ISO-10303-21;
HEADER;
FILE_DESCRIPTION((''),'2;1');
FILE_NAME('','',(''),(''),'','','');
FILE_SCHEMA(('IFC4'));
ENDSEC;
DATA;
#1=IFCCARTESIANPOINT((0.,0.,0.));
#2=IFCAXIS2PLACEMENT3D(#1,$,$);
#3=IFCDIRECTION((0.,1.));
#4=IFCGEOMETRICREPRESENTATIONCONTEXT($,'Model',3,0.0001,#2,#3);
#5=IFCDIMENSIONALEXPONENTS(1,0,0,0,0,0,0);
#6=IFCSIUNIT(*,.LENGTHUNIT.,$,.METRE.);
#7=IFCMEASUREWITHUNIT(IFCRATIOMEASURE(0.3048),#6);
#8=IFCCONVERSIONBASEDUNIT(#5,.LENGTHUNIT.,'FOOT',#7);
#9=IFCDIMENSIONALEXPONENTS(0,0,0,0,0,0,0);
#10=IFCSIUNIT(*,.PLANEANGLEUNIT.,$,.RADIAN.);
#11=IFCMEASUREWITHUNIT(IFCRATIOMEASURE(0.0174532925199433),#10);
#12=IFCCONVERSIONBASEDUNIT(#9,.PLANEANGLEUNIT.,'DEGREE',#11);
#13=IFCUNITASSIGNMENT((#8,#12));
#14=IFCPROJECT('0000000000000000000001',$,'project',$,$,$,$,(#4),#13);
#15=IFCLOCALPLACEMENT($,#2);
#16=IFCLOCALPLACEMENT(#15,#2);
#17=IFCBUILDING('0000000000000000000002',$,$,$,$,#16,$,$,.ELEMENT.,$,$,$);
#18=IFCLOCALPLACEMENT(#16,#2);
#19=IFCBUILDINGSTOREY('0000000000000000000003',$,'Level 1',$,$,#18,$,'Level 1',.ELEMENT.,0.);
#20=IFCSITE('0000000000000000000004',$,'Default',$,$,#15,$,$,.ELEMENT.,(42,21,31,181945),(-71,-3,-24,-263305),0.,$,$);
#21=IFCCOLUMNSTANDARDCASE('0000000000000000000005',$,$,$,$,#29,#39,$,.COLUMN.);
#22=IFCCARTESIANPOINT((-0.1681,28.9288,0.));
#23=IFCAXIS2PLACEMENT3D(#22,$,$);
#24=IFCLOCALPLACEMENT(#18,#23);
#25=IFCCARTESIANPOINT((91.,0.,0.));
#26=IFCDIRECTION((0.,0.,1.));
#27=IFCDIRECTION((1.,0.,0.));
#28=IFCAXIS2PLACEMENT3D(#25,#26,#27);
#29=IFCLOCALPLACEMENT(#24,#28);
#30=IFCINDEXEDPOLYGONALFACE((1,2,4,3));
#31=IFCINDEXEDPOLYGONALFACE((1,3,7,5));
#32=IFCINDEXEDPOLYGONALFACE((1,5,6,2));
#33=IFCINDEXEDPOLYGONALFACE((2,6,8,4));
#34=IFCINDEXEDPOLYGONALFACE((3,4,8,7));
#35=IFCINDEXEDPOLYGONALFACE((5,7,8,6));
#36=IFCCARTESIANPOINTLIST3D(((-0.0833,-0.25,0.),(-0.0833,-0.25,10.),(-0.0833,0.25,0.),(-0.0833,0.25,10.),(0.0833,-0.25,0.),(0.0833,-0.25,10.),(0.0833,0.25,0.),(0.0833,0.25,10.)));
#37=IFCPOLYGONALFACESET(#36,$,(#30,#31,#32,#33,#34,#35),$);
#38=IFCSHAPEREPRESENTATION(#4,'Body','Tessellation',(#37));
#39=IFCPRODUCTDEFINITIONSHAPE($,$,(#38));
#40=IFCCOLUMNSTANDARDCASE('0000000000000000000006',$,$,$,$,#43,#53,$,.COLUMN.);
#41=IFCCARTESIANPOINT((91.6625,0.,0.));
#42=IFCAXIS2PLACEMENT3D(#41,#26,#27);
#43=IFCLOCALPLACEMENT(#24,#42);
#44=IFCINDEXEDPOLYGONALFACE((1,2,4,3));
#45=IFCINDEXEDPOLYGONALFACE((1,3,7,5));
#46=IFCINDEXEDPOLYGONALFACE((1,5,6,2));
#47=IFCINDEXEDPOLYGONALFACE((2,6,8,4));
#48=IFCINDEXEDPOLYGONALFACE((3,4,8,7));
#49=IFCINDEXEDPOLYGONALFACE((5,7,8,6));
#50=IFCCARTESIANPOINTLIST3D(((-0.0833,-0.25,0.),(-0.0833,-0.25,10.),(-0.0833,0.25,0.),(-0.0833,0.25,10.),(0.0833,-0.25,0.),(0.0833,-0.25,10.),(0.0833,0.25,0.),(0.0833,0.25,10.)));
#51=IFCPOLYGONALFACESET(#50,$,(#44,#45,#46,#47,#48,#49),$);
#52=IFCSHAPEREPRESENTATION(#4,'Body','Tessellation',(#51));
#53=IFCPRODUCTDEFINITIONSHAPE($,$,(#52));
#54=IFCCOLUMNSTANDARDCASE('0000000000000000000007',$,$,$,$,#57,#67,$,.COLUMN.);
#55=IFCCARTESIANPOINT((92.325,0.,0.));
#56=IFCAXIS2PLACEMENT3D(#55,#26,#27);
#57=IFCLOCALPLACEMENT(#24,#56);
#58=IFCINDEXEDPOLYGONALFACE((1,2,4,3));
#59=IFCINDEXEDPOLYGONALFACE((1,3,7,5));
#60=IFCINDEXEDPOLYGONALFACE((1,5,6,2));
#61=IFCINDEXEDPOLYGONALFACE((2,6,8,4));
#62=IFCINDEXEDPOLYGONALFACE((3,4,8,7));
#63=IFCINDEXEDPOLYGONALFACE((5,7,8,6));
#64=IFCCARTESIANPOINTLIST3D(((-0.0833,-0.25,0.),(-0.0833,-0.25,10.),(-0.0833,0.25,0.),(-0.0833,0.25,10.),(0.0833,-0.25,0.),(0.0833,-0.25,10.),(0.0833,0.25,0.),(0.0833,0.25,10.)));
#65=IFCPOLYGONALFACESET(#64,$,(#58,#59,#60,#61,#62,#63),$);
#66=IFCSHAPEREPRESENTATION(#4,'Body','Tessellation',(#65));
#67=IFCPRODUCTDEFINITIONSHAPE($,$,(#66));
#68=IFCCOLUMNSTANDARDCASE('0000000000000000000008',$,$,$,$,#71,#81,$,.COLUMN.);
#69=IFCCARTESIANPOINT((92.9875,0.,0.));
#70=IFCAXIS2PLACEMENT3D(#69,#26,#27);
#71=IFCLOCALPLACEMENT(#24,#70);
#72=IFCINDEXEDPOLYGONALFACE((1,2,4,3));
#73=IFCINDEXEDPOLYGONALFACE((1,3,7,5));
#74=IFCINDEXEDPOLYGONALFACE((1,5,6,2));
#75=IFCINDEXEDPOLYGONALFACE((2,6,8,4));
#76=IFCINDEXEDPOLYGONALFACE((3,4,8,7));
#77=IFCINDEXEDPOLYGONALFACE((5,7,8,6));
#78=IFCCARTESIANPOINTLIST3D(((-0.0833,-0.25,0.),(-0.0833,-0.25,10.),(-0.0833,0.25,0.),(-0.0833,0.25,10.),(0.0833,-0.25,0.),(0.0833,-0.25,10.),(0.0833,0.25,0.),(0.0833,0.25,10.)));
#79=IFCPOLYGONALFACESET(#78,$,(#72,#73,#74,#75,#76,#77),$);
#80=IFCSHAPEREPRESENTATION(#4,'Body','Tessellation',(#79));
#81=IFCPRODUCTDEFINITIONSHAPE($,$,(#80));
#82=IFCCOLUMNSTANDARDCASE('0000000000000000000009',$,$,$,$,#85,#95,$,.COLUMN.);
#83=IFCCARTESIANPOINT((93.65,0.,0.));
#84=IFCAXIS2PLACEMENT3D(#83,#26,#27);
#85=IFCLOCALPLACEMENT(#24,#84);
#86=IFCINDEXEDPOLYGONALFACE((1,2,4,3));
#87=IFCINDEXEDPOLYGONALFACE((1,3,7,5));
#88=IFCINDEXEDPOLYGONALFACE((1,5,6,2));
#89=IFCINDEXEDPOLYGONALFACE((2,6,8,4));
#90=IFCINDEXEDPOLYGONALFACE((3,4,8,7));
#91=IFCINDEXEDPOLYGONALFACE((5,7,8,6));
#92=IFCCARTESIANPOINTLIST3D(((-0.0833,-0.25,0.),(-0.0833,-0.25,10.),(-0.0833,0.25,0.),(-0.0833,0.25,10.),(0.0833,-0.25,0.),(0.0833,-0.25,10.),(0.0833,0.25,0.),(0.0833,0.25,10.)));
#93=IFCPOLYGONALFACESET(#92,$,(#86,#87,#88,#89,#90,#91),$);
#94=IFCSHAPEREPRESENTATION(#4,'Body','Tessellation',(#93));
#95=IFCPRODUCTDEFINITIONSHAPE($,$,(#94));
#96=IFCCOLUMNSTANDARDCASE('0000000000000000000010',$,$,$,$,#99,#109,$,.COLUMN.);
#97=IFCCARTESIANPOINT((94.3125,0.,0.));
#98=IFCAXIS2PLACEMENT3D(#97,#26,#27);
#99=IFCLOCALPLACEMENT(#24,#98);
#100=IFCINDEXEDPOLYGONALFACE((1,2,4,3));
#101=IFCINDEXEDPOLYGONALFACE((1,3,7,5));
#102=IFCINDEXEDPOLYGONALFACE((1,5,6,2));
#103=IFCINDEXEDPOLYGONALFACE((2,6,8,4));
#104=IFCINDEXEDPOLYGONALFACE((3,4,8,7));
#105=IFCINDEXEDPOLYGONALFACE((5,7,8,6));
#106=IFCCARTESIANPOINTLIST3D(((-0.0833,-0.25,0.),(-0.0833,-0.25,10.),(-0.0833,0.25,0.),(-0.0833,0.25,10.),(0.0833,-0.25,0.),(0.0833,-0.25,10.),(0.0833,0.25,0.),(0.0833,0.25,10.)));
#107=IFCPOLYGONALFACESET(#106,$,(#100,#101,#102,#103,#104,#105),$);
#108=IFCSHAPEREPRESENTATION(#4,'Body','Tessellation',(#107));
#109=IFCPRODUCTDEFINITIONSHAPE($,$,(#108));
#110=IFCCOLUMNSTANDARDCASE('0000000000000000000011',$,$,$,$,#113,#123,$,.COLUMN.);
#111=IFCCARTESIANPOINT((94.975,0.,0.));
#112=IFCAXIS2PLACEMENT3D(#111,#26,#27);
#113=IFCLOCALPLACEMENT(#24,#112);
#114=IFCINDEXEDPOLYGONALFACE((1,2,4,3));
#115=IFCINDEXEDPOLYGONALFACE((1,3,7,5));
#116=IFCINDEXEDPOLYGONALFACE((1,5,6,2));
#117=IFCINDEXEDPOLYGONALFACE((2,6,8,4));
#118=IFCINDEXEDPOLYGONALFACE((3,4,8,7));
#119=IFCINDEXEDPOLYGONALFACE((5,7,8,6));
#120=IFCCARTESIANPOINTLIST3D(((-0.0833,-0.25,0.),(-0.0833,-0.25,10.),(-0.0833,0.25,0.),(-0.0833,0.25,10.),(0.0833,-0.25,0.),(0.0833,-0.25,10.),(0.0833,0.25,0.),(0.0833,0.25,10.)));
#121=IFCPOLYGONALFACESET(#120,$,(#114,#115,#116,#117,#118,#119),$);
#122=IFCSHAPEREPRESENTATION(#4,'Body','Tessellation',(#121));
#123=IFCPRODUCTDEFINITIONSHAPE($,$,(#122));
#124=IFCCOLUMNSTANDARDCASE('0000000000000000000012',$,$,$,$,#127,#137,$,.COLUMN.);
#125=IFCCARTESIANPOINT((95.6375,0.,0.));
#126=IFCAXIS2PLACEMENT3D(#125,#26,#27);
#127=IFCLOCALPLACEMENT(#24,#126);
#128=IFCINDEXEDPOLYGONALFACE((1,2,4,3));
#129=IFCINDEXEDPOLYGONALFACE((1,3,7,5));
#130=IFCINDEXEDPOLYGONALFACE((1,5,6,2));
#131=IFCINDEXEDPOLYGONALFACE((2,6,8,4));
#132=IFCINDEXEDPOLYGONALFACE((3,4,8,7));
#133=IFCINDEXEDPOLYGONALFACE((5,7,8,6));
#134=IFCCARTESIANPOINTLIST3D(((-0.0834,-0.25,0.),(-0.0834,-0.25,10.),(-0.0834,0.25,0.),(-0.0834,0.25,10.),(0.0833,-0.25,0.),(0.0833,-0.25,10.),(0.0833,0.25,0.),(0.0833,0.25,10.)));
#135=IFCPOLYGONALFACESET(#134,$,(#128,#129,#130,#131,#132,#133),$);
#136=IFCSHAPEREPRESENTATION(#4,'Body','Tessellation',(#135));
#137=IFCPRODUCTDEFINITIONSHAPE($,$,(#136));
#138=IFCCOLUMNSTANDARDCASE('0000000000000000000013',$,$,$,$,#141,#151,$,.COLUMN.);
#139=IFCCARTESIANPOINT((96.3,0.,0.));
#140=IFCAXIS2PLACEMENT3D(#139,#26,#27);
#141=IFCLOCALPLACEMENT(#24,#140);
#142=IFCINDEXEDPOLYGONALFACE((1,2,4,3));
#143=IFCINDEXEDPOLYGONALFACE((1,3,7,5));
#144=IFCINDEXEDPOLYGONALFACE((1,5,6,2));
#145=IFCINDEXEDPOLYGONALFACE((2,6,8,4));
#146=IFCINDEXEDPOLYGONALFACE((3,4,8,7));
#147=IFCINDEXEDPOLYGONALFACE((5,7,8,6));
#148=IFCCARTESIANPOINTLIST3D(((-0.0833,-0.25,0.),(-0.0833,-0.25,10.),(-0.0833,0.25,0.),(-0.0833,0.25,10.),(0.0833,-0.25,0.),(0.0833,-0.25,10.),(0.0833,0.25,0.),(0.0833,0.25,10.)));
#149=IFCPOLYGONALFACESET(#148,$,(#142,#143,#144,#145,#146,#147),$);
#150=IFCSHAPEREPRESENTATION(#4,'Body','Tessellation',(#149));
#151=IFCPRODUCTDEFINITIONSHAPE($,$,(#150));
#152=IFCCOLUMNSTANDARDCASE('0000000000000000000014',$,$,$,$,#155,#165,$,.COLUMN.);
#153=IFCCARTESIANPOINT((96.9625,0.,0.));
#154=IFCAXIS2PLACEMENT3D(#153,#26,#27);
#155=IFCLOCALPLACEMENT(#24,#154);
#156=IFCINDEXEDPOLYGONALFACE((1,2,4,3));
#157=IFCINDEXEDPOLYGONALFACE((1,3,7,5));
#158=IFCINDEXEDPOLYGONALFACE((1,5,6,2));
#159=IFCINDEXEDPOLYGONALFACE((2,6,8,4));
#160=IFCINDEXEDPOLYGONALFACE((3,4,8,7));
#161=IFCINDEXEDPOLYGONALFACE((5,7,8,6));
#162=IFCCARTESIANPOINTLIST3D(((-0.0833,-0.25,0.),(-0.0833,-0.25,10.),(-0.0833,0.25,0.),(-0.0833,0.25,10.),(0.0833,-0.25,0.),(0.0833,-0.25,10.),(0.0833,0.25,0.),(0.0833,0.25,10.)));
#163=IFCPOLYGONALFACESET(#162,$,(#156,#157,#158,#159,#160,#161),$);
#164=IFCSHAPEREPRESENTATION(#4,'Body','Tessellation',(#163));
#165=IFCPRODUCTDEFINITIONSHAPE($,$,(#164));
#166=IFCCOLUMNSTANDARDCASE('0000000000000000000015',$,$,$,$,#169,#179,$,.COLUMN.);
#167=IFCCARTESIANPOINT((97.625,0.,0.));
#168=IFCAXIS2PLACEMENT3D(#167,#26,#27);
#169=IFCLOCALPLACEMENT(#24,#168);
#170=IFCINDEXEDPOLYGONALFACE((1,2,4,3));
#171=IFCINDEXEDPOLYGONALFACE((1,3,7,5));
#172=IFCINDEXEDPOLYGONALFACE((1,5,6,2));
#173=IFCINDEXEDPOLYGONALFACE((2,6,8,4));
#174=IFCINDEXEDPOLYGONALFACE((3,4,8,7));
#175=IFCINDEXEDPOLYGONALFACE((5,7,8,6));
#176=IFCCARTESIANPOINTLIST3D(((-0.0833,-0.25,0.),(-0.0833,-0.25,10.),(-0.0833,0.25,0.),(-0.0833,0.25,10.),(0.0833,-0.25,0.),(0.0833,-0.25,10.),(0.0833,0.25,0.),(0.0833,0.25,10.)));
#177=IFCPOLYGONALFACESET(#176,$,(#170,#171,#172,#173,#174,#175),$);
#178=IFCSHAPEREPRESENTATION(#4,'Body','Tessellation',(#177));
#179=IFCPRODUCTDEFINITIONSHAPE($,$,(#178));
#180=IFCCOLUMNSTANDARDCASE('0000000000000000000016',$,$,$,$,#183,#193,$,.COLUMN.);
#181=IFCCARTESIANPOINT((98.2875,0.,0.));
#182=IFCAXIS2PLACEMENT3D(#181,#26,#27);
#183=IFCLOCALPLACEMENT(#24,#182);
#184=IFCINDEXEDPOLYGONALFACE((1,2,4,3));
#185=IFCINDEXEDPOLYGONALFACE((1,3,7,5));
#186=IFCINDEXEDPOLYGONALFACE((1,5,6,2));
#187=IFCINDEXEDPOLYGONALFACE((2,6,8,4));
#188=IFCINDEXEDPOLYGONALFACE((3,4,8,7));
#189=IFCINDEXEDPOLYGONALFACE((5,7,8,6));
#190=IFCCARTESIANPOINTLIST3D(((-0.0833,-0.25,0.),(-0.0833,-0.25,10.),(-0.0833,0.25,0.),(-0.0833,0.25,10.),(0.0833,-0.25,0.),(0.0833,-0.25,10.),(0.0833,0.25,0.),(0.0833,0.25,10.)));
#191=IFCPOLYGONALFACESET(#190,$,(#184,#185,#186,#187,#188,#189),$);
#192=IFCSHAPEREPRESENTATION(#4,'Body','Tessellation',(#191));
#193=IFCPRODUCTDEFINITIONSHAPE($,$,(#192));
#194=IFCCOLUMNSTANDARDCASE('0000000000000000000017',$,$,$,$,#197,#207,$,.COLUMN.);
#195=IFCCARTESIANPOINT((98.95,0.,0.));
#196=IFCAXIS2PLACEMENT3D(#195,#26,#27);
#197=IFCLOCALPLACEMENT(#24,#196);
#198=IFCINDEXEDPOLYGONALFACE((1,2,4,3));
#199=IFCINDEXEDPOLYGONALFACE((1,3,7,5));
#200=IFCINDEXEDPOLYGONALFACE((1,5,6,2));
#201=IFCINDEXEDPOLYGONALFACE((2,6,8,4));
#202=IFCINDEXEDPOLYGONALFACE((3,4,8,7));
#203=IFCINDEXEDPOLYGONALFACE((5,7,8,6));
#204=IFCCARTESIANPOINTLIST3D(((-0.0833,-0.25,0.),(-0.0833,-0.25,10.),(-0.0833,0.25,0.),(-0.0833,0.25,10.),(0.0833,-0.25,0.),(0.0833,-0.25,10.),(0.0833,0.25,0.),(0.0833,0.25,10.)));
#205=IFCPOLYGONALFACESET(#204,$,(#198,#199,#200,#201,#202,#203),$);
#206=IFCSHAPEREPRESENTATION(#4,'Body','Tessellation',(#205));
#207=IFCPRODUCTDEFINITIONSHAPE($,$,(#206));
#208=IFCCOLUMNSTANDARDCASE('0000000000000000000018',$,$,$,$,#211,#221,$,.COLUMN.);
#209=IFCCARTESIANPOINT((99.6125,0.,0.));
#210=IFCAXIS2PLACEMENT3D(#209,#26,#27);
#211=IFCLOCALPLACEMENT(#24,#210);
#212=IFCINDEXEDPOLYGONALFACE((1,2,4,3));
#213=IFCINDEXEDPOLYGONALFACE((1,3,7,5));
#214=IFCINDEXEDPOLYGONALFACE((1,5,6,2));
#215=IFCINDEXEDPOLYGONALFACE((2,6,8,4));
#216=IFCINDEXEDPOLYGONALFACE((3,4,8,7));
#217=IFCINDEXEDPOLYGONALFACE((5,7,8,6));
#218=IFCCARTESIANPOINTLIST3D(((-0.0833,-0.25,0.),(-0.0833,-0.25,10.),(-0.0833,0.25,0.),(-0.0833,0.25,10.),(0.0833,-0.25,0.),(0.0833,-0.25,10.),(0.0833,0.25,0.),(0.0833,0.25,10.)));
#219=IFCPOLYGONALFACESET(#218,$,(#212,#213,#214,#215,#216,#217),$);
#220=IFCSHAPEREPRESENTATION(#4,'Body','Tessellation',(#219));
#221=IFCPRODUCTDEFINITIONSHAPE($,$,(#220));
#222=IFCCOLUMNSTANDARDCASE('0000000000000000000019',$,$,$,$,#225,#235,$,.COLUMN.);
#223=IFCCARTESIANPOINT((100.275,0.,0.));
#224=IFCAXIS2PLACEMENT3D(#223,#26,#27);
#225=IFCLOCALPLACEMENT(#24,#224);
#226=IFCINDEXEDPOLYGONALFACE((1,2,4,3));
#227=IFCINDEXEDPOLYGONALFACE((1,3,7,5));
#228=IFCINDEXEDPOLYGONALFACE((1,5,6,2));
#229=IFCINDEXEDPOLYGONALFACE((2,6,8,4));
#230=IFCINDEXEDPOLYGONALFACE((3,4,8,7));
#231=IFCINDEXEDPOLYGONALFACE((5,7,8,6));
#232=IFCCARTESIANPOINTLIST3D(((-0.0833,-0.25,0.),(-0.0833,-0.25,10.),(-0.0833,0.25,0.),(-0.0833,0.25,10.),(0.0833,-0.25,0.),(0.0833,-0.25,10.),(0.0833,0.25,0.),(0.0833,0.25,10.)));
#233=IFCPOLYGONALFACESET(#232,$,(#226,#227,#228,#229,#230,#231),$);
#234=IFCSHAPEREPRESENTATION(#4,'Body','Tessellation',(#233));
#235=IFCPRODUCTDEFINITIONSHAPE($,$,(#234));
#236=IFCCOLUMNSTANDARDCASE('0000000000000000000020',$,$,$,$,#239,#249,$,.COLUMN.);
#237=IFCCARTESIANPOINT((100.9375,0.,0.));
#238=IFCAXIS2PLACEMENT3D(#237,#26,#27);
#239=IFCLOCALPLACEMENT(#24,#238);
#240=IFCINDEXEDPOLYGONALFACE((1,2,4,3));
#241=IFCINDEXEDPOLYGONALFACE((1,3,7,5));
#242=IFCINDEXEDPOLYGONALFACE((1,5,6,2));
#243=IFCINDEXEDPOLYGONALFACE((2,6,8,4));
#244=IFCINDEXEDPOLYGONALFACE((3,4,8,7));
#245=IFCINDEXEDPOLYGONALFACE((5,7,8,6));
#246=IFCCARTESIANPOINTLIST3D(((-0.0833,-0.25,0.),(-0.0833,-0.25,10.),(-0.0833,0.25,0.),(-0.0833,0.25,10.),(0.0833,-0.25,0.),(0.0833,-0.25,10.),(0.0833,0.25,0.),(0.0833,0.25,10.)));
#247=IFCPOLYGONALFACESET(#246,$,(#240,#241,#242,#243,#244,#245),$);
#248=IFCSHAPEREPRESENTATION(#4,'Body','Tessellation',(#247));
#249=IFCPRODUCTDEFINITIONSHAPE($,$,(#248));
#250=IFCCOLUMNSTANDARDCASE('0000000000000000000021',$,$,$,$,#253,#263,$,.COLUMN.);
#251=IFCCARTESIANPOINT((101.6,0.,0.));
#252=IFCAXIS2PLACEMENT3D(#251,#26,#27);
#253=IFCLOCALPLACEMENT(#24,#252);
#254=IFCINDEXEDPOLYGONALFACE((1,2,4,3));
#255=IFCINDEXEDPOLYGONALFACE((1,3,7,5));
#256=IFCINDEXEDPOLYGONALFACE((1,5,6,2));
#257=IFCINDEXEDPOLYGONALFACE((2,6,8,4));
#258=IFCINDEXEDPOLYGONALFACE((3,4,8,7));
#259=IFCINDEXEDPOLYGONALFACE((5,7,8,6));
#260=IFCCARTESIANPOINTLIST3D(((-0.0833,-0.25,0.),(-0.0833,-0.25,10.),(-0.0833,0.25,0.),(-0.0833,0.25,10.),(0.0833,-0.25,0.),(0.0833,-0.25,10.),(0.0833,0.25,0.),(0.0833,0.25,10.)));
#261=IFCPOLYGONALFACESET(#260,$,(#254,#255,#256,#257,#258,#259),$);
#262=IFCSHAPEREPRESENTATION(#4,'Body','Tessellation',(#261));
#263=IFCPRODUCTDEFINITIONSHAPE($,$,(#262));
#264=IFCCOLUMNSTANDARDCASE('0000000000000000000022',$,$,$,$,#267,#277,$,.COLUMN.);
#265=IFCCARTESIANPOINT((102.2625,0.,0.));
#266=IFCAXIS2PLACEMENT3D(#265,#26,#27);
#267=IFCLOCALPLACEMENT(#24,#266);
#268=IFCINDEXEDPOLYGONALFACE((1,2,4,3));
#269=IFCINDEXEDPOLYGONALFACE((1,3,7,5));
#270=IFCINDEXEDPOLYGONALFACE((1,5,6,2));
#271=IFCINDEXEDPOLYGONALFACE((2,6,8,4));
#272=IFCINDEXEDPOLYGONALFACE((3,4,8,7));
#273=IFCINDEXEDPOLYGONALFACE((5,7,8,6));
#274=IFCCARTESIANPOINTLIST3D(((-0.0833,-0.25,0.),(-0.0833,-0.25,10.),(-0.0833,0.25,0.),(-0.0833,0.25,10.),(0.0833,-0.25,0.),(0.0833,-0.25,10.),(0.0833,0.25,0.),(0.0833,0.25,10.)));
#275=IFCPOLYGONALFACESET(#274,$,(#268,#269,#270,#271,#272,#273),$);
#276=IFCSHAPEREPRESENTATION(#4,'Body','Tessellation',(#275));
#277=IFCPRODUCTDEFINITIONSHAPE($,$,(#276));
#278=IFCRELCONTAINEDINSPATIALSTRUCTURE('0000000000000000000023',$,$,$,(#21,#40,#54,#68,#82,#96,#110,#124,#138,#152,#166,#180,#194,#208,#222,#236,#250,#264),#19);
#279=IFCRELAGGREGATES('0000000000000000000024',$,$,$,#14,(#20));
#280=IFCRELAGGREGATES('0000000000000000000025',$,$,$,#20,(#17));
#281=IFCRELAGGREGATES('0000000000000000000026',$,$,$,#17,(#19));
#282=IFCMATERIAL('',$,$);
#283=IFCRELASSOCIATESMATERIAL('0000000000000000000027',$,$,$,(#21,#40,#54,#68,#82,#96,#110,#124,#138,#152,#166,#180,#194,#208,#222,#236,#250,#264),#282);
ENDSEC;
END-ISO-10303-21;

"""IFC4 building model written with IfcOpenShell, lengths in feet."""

from ifc_helpers import new_model, entity, si_unit, converted_unit, direction, frame, origin, place, context, project, spatial, rectangle, extrude, material, element, save


model = new_model("IFC4")

# Units and contexts
model_context = context("Model", 3, precision=0.0001, world=origin(), true_north=direction((0.0, 1.0)))
ifc_project = project(units=[converted_unit("LENGTHUNIT", "FOOT", entity("IfcRatioMeasure", 0.3048), si_unit("LENGTHUNIT", "METRE"), dimensions=[1, 0, 0, 0, 0, 0, 0]), converted_unit("PLANEANGLEUNIT", "DEGREE", entity("IfcRatioMeasure", 0.0174532925199433), si_unit("PLANEANGLEUNIT", "RADIAN"), dimensions=[0, 0, 0, 0, 0, 0, 0])], contexts=[model_context])

# Site, building, storey
site_placement = place(None, origin())
site = spatial("IfcSite", under=ifc_project, at=site_placement, Name="Default", CompositionType="ELEMENT", RefLatitude=(42, 21, 31, 181945), RefLongitude=(-71, -3, -24, -263305), RefElevation=0.0)
building_placement = place(site_placement, origin())
building = spatial("IfcBuilding", under=site, at=building_placement, CompositionType="ELEMENT")
storey_placement = place(building_placement, origin())
storey = spatial("IfcBuildingStorey", under=building, at=storey_placement, Name="Level 1", LongName="Level 1", CompositionType="ELEMENT", Elevation=0.0)

# Columns
ifc_material_1 = material(Name="")
placement = place(storey_placement, frame((-0.1681, 28.9288, 0.0)))
for number, where, z_axis, x_axis in (
    (1, (91.0, 0.0, 0.0), (0.0, 0.0, 1.0), (1.0, 0.0, 0.0)),
    (2, (91.6625, 0.0, 0.0), (0.0, 0.0, 1.0), (1.0, 0.0, 0.0)),
    (3, (92.325, 0.0, 0.0), (0.0, 0.0, 1.0), (1.0, 0.0, 0.0)),
    (4, (92.9875, 0.0, 0.0), (0.0, 0.0, 1.0), (1.0, 0.0, 0.0)),
    (5, (93.65, 0.0, 0.0), (0.0, 0.0, 1.0), (1.0, 0.0, 0.0)),
    (6, (94.3125, 0.0, 0.0), (0.0, 0.0, 1.0), (1.0, 0.0, 0.0)),
    (7, (94.975, 0.0, 0.0), (0.0, 0.0, 1.0), (1.0, 0.0, 0.0)),
    (8, (95.6375, 0.0, 0.0), (0.0, 0.0, 1.0), (1.0, 0.0, 0.0)),
    (9, (96.3, 0.0, 0.0), (0.0, 0.0, 1.0), (1.0, 0.0, 0.0)),
    (10, (96.9625, 0.0, 0.0), (0.0, 0.0, 1.0), (1.0, 0.0, 0.0)),
    (11, (97.625, 0.0, 0.0), (0.0, 0.0, 1.0), (1.0, 0.0, 0.0)),
    (12, (98.2875, 0.0, 0.0), (0.0, 0.0, 1.0), (1.0, 0.0, 0.0)),
    (13, (98.95, 0.0, 0.0), (0.0, 0.0, 1.0), (1.0, 0.0, 0.0)),
    (14, (99.6125, 0.0, 0.0), (0.0, 0.0, 1.0), (1.0, 0.0, 0.0)),
    (15, (100.275, 0.0, 0.0), (0.0, 0.0, 1.0), (1.0, 0.0, 0.0)),
    (16, (100.9375, 0.0, 0.0), (0.0, 0.0, 1.0), (1.0, 0.0, 0.0)),
    (17, (101.6, 0.0, 0.0), (0.0, 0.0, 1.0), (1.0, 0.0, 0.0)),
    (18, (102.2625, 0.0, 0.0), (0.0, 0.0, 1.0), (1.0, 0.0, 0.0)),
):
    element("IfcColumnStandardCase", number, at=place(placement, frame(where, z_axis=z_axis, x_axis=x_axis)), inside=storey, material=ifc_material_1, PredefinedType="COLUMN", context=model_context, shape_type="SweptSolid", body=[
        extrude(rectangle(XDim=0.1667, YDim=0.5), origin(), (0.0, 0.0, 1.0), 10.0),
    ])

save(model, "model.ifc")
